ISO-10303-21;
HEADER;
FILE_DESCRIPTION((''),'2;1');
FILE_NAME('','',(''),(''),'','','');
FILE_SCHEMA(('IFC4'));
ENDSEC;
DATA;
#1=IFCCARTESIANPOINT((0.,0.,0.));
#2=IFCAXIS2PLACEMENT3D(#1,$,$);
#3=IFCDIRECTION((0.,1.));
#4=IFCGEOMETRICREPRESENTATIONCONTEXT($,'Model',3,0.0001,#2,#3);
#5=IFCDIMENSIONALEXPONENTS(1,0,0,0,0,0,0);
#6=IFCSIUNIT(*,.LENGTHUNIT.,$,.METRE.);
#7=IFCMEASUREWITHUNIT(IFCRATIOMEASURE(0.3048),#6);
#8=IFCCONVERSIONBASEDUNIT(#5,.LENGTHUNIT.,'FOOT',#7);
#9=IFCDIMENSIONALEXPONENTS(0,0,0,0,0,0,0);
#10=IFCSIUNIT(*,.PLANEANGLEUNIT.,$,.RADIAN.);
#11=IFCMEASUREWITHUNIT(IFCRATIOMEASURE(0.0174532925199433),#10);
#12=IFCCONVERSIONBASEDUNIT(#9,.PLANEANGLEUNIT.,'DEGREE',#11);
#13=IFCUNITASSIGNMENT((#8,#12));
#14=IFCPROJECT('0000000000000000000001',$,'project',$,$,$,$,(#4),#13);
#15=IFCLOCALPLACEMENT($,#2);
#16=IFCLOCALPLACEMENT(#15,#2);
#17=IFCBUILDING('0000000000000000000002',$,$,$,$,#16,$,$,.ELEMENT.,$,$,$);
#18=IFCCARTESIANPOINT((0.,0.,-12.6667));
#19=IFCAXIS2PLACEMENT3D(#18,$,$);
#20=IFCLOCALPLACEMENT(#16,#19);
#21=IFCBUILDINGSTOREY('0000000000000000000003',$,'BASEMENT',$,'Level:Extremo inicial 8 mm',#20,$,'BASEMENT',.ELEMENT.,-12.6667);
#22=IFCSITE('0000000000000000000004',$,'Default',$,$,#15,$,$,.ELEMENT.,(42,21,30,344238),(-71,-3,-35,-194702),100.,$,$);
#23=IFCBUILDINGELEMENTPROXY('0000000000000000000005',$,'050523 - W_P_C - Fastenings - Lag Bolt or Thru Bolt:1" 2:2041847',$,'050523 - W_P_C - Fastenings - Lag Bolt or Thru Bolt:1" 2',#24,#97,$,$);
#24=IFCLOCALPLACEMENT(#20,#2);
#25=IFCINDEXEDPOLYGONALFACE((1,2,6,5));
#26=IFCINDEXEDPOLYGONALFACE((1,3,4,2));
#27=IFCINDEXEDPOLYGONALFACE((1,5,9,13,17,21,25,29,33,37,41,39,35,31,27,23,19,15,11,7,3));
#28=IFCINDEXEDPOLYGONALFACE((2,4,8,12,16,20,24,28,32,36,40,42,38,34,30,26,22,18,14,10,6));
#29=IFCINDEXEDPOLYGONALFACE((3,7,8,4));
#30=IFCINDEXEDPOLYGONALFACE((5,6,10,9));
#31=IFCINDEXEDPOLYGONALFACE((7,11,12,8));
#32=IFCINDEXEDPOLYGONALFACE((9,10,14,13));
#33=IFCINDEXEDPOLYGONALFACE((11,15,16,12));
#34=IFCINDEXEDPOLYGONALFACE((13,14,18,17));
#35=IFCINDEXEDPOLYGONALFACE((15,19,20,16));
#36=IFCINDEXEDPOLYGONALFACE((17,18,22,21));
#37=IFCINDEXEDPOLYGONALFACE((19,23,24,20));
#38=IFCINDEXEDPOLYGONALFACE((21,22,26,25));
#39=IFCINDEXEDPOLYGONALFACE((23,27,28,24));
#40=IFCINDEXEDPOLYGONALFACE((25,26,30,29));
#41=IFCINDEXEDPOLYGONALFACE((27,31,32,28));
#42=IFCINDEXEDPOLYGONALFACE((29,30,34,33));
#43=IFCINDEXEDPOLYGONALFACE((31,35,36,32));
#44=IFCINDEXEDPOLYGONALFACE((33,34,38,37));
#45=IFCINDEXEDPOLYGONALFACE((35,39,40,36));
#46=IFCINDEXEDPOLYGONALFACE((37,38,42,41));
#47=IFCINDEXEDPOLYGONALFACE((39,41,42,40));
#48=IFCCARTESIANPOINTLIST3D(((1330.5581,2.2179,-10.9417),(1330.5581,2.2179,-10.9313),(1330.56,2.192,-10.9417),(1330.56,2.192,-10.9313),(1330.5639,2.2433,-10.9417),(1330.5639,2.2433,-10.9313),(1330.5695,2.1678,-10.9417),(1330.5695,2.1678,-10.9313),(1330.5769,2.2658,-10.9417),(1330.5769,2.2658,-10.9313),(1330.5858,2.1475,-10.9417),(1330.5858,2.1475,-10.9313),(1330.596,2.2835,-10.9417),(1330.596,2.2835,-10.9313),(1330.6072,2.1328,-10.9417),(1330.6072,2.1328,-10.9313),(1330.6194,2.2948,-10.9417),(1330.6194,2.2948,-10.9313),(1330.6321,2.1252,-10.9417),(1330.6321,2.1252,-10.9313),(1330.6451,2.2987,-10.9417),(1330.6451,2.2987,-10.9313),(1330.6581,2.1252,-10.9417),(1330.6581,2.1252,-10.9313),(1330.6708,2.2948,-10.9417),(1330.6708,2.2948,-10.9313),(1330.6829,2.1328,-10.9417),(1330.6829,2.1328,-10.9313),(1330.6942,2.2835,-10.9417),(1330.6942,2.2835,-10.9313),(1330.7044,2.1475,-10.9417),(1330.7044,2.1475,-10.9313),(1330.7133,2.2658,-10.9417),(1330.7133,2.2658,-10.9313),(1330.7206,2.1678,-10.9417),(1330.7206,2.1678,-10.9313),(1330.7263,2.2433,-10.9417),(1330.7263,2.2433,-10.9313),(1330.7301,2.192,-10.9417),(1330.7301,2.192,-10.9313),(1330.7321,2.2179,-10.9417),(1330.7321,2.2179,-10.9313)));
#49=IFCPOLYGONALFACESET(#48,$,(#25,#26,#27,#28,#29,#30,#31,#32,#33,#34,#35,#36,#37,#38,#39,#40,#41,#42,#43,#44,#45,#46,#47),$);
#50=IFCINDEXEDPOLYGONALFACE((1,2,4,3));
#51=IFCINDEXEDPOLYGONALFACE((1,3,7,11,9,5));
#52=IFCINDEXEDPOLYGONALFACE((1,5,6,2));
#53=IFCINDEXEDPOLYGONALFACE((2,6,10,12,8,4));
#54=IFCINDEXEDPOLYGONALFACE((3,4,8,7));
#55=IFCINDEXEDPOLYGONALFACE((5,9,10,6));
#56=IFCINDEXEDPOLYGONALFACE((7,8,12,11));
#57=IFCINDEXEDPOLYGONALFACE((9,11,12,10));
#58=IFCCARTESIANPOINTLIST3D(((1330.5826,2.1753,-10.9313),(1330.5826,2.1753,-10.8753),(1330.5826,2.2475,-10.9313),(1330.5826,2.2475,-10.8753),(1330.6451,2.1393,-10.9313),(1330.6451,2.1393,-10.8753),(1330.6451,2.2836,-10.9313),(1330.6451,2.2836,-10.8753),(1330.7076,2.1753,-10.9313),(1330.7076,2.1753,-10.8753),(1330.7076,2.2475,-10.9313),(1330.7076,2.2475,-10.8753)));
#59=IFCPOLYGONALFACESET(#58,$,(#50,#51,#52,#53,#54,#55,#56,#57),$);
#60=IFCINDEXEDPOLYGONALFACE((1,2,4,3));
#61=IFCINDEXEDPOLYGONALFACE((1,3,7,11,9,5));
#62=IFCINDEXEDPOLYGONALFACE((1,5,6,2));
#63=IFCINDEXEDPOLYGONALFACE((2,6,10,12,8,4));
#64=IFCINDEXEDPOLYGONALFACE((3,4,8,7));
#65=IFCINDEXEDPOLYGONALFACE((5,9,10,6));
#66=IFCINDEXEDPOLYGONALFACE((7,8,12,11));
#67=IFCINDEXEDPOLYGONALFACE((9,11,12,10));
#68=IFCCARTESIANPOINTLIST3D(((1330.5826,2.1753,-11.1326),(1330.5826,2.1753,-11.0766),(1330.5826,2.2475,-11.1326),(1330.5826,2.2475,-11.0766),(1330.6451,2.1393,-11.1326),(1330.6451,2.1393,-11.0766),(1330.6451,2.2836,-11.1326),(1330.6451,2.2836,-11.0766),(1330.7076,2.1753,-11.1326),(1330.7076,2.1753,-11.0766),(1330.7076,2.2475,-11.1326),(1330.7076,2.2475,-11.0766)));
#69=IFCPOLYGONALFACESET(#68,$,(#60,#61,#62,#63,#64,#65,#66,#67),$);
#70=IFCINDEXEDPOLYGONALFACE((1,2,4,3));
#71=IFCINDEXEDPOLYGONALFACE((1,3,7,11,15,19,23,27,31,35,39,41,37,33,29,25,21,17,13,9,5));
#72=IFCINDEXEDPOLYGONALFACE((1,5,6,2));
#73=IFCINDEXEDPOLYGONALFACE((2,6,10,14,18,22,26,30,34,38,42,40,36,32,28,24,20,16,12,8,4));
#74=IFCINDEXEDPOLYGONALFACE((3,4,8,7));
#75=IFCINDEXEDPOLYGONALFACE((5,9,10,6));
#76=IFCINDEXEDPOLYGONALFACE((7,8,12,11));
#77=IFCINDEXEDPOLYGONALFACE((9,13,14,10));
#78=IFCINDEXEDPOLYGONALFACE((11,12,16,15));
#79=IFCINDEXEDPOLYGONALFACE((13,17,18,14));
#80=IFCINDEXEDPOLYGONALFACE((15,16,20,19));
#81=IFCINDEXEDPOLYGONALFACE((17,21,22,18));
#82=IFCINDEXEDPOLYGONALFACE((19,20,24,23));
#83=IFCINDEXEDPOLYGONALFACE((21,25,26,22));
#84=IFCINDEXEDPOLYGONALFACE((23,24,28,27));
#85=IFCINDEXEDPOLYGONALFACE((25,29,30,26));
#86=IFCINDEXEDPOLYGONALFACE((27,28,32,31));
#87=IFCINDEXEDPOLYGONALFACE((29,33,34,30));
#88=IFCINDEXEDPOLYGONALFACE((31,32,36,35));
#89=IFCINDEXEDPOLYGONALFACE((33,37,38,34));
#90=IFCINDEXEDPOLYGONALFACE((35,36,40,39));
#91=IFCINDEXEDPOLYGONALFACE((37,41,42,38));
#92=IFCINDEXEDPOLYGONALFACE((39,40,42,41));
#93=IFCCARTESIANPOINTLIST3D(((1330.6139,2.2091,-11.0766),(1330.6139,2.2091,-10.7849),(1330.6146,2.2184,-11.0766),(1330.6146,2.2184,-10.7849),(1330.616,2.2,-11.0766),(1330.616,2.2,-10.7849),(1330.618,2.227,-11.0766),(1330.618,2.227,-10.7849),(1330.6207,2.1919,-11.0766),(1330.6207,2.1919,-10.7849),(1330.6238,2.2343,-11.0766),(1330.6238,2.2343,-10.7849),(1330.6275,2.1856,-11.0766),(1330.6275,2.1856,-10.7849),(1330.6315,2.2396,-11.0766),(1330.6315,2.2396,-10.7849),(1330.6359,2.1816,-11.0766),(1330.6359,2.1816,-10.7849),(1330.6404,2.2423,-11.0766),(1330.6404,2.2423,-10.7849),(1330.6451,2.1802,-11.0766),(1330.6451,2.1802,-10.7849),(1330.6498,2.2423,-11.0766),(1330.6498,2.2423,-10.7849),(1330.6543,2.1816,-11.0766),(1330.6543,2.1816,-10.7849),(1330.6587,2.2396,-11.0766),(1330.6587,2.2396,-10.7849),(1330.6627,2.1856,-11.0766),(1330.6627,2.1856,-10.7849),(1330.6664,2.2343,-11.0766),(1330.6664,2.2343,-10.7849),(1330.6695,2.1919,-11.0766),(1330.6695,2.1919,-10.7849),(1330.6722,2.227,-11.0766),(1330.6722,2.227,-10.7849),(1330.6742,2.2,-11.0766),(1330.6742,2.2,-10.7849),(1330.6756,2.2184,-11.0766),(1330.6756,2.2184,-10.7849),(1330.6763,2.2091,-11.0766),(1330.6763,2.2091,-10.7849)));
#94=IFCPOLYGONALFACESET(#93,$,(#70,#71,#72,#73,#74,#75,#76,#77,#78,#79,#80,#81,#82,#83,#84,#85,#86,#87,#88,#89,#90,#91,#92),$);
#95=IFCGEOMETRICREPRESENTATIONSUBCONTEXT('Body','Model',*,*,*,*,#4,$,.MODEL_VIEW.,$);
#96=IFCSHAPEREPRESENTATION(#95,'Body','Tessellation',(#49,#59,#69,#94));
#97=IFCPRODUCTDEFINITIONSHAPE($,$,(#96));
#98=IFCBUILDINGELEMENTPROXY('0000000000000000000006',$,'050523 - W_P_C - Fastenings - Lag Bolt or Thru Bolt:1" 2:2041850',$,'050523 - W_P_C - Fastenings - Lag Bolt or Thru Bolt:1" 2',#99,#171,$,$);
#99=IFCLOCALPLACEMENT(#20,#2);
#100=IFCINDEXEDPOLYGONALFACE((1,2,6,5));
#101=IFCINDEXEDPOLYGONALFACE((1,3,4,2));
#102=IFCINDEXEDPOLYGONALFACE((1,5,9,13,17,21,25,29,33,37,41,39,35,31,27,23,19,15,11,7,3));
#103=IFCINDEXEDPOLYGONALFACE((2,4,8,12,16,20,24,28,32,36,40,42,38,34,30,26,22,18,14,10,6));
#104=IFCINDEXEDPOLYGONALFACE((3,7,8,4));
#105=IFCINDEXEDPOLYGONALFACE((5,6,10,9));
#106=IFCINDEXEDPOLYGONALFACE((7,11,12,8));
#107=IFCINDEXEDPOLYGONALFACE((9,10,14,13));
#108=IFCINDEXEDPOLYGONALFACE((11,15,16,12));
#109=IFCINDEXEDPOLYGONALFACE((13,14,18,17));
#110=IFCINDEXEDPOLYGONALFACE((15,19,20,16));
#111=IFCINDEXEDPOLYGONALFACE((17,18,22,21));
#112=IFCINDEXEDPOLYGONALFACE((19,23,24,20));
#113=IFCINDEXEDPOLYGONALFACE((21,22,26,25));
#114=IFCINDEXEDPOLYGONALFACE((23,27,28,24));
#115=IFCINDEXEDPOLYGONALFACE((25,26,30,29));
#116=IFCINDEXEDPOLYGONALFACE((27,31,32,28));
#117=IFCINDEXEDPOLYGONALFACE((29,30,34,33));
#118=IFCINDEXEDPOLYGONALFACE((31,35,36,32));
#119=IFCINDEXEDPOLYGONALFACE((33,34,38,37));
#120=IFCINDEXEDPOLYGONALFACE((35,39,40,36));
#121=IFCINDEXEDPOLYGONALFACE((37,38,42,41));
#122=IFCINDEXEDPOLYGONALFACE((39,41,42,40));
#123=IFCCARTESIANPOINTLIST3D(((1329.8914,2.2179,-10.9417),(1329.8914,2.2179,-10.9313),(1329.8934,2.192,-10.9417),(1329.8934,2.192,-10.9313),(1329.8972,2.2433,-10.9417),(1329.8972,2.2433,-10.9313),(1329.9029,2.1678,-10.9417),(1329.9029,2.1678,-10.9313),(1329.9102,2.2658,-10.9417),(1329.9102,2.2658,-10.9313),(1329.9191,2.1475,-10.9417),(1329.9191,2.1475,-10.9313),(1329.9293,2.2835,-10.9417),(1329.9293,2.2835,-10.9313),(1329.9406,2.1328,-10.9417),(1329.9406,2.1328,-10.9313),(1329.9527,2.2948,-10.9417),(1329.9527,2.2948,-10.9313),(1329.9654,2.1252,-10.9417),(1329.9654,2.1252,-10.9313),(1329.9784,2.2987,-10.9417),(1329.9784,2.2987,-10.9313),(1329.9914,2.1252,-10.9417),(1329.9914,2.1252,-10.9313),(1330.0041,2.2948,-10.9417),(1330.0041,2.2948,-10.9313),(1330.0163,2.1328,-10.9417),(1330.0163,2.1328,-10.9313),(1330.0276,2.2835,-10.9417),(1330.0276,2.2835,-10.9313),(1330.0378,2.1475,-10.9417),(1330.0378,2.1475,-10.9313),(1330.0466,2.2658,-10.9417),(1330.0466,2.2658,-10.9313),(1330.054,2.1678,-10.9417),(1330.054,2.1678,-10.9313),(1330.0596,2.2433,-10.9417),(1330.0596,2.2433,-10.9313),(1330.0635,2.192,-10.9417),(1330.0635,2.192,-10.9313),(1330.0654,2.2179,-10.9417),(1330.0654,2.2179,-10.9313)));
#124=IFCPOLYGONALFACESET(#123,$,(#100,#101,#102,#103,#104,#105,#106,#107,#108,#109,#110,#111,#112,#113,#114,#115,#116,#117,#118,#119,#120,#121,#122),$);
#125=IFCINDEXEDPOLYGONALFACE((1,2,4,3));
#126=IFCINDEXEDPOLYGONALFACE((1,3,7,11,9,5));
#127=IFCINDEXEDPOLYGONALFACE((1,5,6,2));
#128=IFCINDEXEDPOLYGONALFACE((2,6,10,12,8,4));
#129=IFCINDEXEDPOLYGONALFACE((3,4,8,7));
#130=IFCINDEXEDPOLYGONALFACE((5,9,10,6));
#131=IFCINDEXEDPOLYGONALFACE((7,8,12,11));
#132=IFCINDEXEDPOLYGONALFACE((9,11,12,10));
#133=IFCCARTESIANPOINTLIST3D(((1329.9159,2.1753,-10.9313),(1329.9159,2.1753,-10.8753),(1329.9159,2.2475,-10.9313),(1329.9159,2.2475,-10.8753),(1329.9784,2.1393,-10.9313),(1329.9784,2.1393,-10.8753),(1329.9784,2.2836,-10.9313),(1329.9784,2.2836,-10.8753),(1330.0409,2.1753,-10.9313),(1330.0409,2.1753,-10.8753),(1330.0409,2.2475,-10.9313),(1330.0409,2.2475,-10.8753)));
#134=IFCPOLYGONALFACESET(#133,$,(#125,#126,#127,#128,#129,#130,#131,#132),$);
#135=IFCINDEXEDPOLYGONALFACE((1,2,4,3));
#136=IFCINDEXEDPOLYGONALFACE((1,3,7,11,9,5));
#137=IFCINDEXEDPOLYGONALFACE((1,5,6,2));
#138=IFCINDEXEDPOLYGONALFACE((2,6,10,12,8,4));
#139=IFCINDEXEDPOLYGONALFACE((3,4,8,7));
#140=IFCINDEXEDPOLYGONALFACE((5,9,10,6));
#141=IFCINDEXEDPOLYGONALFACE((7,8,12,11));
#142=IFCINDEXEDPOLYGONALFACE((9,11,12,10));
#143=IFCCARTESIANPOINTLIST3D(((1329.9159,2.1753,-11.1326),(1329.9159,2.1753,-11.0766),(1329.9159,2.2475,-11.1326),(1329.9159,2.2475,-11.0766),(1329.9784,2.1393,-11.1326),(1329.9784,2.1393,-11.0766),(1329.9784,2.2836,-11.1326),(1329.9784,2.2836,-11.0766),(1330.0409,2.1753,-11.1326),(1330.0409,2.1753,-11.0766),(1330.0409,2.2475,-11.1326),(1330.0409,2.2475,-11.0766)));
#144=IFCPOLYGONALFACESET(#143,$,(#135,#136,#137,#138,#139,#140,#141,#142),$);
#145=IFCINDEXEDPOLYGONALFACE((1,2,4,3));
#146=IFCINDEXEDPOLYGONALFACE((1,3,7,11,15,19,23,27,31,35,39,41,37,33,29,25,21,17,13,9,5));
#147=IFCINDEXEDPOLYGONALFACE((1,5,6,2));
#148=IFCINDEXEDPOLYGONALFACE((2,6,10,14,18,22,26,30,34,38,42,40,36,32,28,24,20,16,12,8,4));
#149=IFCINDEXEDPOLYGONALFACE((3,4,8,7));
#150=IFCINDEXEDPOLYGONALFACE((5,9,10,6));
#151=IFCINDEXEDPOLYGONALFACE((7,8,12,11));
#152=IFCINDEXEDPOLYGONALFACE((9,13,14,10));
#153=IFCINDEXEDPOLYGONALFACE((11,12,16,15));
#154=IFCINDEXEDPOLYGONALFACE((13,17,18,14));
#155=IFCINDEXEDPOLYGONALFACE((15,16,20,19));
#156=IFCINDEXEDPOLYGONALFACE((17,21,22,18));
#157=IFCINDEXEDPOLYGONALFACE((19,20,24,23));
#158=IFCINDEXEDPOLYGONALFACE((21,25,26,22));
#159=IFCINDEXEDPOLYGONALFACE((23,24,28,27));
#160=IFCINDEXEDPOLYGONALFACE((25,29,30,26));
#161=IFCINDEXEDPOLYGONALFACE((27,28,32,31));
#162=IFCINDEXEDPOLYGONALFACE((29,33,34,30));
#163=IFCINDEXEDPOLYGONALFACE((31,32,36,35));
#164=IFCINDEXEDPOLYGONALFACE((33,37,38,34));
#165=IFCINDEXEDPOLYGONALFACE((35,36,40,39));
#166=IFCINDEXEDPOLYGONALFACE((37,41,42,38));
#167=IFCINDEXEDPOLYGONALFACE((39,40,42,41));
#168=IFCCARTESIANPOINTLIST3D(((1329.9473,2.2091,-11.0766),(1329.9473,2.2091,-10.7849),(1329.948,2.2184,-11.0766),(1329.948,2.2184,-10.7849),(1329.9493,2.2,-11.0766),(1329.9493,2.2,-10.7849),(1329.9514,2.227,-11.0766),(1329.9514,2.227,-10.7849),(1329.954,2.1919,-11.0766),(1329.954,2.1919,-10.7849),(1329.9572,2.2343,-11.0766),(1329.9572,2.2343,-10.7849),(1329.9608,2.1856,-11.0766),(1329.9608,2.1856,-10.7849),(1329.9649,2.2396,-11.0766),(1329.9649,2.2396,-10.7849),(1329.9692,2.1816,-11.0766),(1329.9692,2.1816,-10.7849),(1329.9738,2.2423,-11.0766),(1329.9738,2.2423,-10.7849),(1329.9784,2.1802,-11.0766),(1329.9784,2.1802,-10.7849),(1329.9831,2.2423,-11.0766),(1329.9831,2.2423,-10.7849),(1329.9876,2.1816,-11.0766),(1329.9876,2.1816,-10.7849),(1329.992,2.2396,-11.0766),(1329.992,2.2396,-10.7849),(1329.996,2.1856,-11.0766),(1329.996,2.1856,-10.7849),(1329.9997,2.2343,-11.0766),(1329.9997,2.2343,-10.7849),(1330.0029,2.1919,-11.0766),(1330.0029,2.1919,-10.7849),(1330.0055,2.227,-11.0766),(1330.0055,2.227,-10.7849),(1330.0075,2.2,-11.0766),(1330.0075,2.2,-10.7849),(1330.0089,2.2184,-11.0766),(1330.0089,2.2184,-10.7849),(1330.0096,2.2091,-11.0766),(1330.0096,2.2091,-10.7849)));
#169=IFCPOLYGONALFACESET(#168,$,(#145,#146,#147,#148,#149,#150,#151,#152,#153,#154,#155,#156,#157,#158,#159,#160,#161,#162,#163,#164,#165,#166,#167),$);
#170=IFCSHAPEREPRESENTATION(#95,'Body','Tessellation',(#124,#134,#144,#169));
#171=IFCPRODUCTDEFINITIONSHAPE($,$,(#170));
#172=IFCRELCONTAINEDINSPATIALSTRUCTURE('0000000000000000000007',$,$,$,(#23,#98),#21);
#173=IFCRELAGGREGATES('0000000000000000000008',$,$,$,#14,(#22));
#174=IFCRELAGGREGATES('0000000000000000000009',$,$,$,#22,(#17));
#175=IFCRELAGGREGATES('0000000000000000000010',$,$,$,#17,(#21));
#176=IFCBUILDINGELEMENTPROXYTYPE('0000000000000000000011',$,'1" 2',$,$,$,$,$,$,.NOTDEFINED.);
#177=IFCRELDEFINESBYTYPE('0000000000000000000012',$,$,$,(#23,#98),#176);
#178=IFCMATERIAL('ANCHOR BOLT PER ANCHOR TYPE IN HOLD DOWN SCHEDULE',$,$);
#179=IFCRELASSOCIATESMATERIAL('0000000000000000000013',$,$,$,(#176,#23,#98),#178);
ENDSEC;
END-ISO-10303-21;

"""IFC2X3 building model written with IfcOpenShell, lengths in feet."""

from ifc_helpers import new_model, entity, si_unit, converted_unit, direction, frame, frame_2d, origin, place, context, subcontext, project, spatial, polyline, circle, outline, extrude, source, transform, mapped, material, type_object, type_shapes, element, save


model = new_model("IFC2X3")

# Units and contexts
model_context = context("Model", 3, precision=0.0001, world=origin(), true_north=direction((0.0, 1.0)))
body_context = subcontext(model_context, "Body", "Model", "MODEL_VIEW")
ifc_project = project(units=[converted_unit("LENGTHUNIT", "FOOT", entity("IfcRatioMeasure", 0.3048), si_unit("LENGTHUNIT", "METRE"), dimensions=[1, 0, 0, 0, 0, 0, 0]), converted_unit("PLANEANGLEUNIT", "DEGREE", entity("IfcRatioMeasure", 0.0174532925199433), si_unit("PLANEANGLEUNIT", "RADIAN"), dimensions=[0, 0, 0, 0, 0, 0, 0])], contexts=[model_context])

# Site, building, storey
site_placement = place(None, origin())
site = spatial("IfcSite", under=ifc_project, at=site_placement, Name="Default", CompositionType="ELEMENT", RefLatitude=(42, 21, 30, 344238), RefLongitude=(-71, -3, -35, -194702), RefElevation=100.0)
building_placement = place(site_placement, origin())
building = spatial("IfcBuilding", under=site, at=building_placement, CompositionType="ELEMENT")
storey_placement = place(building_placement, frame((0.0, 0.0, -12.6667)))
storey = spatial("IfcBuildingStorey", under=building, at=storey_placement, Name="BASEMENT", ObjectType="Level:Extremo inicial 8 mm", LongName="BASEMENT", CompositionType="ELEMENT", Elevation=-12.6667)

# Building element proxies
ifc_material_1 = material(Name="ANCHOR BOLT PER ANCHOR TYPE IN HOLD DOWN SCHEDULE")
building_element_proxy_type_1 = type_object("IfcBuildingElementProxyType", Name="1\" 2", PredefinedType="NOTDEFINED", material=ifc_material_1)
shared_shape_1 = source(origin(), body_context, "Body", "SweptSolid", [
    extrude(circle(Radius=0.0872, at=frame_2d((0.0, 0.0), x_axis=(1.0, 0.0))), frame((0.0, 0.0, -0.1453), z_axis=(0.0, 0.0, 1.0), x_axis=(0.0, -1.0, 0.0)), (0.0, 0.0, 1.0), 0.0104),
    extrude(outline(polyline([(-0.0361, -0.0625), (0.0361, -0.0625), (0.0722, 0.0), (0.0361, 0.0625), (-0.0361, 0.0625), (-0.0722, 0.0), (-0.0361, -0.0625)])), frame((0.0, 0.0, -0.2013), z_axis=(0.0, 0.0, 1.0), x_axis=(0.866025, -0.5, 0.0)), (0.0, 0.0, 1.0), 0.056),
    extrude(outline(polyline([(-0.0361, -0.0625), (0.0361, -0.0625), (0.0722, 0.0), (0.0361, 0.0625), (-0.0361, 0.0625), (-0.0722, 0.0), (-0.0361, -0.0625)])), frame((0.0, 0.0, 0.0), z_axis=(0.0, 0.0, 1.0), x_axis=(0.0, -1.0, 0.0)), (0.0, 0.0, 1.0), 0.056),
    extrude(circle(Radius=0.0312, at=frame_2d((0.0, 0.0), x_axis=(1.0, 0.0))), frame((0.0, 0.0, -0.2917), z_axis=(0.0, 0.0, 1.0), x_axis=(0.0, 1.0, 0.0)), (0.0, 0.0, 1.0), 0.2917),
])
type_shapes(building_element_proxy_type_1, [shared_shape_1])
for number, where, z_axis, x_axis, name in (
    (1, (1330.6451, 2.2114, -11.0766), (0.0, 0.0, -1.0), (1.0, 0.0, 0.0), "050523 - W_P_C - Fastenings - Lag Bolt or Thru Bolt:1\" 2:2041847"),
    (2, (1329.9784, 2.2114, -11.0766), (0.0, 0.0, -1.0), (1.0, 0.0, 0.0), "050523 - W_P_C - Fastenings - Lag Bolt or Thru Bolt:1\" 2:2041850"),
):
    element("IfcBuildingElementProxy", number, at=place(storey_placement, frame(where, z_axis=z_axis, x_axis=x_axis)), inside=storey, type_object=building_element_proxy_type_1, material=ifc_material_1, Name=name, ObjectType="050523 - W_P_C - Fastenings - Lag Bolt or Thru Bolt:1\" 2", context=body_context, shape_type="MappedRepresentation", body=[
        mapped(shared_shape_1, transform((0.0, 0.0, 0.0), scale=1.0)),
    ])

save(model, "model.ifc")
